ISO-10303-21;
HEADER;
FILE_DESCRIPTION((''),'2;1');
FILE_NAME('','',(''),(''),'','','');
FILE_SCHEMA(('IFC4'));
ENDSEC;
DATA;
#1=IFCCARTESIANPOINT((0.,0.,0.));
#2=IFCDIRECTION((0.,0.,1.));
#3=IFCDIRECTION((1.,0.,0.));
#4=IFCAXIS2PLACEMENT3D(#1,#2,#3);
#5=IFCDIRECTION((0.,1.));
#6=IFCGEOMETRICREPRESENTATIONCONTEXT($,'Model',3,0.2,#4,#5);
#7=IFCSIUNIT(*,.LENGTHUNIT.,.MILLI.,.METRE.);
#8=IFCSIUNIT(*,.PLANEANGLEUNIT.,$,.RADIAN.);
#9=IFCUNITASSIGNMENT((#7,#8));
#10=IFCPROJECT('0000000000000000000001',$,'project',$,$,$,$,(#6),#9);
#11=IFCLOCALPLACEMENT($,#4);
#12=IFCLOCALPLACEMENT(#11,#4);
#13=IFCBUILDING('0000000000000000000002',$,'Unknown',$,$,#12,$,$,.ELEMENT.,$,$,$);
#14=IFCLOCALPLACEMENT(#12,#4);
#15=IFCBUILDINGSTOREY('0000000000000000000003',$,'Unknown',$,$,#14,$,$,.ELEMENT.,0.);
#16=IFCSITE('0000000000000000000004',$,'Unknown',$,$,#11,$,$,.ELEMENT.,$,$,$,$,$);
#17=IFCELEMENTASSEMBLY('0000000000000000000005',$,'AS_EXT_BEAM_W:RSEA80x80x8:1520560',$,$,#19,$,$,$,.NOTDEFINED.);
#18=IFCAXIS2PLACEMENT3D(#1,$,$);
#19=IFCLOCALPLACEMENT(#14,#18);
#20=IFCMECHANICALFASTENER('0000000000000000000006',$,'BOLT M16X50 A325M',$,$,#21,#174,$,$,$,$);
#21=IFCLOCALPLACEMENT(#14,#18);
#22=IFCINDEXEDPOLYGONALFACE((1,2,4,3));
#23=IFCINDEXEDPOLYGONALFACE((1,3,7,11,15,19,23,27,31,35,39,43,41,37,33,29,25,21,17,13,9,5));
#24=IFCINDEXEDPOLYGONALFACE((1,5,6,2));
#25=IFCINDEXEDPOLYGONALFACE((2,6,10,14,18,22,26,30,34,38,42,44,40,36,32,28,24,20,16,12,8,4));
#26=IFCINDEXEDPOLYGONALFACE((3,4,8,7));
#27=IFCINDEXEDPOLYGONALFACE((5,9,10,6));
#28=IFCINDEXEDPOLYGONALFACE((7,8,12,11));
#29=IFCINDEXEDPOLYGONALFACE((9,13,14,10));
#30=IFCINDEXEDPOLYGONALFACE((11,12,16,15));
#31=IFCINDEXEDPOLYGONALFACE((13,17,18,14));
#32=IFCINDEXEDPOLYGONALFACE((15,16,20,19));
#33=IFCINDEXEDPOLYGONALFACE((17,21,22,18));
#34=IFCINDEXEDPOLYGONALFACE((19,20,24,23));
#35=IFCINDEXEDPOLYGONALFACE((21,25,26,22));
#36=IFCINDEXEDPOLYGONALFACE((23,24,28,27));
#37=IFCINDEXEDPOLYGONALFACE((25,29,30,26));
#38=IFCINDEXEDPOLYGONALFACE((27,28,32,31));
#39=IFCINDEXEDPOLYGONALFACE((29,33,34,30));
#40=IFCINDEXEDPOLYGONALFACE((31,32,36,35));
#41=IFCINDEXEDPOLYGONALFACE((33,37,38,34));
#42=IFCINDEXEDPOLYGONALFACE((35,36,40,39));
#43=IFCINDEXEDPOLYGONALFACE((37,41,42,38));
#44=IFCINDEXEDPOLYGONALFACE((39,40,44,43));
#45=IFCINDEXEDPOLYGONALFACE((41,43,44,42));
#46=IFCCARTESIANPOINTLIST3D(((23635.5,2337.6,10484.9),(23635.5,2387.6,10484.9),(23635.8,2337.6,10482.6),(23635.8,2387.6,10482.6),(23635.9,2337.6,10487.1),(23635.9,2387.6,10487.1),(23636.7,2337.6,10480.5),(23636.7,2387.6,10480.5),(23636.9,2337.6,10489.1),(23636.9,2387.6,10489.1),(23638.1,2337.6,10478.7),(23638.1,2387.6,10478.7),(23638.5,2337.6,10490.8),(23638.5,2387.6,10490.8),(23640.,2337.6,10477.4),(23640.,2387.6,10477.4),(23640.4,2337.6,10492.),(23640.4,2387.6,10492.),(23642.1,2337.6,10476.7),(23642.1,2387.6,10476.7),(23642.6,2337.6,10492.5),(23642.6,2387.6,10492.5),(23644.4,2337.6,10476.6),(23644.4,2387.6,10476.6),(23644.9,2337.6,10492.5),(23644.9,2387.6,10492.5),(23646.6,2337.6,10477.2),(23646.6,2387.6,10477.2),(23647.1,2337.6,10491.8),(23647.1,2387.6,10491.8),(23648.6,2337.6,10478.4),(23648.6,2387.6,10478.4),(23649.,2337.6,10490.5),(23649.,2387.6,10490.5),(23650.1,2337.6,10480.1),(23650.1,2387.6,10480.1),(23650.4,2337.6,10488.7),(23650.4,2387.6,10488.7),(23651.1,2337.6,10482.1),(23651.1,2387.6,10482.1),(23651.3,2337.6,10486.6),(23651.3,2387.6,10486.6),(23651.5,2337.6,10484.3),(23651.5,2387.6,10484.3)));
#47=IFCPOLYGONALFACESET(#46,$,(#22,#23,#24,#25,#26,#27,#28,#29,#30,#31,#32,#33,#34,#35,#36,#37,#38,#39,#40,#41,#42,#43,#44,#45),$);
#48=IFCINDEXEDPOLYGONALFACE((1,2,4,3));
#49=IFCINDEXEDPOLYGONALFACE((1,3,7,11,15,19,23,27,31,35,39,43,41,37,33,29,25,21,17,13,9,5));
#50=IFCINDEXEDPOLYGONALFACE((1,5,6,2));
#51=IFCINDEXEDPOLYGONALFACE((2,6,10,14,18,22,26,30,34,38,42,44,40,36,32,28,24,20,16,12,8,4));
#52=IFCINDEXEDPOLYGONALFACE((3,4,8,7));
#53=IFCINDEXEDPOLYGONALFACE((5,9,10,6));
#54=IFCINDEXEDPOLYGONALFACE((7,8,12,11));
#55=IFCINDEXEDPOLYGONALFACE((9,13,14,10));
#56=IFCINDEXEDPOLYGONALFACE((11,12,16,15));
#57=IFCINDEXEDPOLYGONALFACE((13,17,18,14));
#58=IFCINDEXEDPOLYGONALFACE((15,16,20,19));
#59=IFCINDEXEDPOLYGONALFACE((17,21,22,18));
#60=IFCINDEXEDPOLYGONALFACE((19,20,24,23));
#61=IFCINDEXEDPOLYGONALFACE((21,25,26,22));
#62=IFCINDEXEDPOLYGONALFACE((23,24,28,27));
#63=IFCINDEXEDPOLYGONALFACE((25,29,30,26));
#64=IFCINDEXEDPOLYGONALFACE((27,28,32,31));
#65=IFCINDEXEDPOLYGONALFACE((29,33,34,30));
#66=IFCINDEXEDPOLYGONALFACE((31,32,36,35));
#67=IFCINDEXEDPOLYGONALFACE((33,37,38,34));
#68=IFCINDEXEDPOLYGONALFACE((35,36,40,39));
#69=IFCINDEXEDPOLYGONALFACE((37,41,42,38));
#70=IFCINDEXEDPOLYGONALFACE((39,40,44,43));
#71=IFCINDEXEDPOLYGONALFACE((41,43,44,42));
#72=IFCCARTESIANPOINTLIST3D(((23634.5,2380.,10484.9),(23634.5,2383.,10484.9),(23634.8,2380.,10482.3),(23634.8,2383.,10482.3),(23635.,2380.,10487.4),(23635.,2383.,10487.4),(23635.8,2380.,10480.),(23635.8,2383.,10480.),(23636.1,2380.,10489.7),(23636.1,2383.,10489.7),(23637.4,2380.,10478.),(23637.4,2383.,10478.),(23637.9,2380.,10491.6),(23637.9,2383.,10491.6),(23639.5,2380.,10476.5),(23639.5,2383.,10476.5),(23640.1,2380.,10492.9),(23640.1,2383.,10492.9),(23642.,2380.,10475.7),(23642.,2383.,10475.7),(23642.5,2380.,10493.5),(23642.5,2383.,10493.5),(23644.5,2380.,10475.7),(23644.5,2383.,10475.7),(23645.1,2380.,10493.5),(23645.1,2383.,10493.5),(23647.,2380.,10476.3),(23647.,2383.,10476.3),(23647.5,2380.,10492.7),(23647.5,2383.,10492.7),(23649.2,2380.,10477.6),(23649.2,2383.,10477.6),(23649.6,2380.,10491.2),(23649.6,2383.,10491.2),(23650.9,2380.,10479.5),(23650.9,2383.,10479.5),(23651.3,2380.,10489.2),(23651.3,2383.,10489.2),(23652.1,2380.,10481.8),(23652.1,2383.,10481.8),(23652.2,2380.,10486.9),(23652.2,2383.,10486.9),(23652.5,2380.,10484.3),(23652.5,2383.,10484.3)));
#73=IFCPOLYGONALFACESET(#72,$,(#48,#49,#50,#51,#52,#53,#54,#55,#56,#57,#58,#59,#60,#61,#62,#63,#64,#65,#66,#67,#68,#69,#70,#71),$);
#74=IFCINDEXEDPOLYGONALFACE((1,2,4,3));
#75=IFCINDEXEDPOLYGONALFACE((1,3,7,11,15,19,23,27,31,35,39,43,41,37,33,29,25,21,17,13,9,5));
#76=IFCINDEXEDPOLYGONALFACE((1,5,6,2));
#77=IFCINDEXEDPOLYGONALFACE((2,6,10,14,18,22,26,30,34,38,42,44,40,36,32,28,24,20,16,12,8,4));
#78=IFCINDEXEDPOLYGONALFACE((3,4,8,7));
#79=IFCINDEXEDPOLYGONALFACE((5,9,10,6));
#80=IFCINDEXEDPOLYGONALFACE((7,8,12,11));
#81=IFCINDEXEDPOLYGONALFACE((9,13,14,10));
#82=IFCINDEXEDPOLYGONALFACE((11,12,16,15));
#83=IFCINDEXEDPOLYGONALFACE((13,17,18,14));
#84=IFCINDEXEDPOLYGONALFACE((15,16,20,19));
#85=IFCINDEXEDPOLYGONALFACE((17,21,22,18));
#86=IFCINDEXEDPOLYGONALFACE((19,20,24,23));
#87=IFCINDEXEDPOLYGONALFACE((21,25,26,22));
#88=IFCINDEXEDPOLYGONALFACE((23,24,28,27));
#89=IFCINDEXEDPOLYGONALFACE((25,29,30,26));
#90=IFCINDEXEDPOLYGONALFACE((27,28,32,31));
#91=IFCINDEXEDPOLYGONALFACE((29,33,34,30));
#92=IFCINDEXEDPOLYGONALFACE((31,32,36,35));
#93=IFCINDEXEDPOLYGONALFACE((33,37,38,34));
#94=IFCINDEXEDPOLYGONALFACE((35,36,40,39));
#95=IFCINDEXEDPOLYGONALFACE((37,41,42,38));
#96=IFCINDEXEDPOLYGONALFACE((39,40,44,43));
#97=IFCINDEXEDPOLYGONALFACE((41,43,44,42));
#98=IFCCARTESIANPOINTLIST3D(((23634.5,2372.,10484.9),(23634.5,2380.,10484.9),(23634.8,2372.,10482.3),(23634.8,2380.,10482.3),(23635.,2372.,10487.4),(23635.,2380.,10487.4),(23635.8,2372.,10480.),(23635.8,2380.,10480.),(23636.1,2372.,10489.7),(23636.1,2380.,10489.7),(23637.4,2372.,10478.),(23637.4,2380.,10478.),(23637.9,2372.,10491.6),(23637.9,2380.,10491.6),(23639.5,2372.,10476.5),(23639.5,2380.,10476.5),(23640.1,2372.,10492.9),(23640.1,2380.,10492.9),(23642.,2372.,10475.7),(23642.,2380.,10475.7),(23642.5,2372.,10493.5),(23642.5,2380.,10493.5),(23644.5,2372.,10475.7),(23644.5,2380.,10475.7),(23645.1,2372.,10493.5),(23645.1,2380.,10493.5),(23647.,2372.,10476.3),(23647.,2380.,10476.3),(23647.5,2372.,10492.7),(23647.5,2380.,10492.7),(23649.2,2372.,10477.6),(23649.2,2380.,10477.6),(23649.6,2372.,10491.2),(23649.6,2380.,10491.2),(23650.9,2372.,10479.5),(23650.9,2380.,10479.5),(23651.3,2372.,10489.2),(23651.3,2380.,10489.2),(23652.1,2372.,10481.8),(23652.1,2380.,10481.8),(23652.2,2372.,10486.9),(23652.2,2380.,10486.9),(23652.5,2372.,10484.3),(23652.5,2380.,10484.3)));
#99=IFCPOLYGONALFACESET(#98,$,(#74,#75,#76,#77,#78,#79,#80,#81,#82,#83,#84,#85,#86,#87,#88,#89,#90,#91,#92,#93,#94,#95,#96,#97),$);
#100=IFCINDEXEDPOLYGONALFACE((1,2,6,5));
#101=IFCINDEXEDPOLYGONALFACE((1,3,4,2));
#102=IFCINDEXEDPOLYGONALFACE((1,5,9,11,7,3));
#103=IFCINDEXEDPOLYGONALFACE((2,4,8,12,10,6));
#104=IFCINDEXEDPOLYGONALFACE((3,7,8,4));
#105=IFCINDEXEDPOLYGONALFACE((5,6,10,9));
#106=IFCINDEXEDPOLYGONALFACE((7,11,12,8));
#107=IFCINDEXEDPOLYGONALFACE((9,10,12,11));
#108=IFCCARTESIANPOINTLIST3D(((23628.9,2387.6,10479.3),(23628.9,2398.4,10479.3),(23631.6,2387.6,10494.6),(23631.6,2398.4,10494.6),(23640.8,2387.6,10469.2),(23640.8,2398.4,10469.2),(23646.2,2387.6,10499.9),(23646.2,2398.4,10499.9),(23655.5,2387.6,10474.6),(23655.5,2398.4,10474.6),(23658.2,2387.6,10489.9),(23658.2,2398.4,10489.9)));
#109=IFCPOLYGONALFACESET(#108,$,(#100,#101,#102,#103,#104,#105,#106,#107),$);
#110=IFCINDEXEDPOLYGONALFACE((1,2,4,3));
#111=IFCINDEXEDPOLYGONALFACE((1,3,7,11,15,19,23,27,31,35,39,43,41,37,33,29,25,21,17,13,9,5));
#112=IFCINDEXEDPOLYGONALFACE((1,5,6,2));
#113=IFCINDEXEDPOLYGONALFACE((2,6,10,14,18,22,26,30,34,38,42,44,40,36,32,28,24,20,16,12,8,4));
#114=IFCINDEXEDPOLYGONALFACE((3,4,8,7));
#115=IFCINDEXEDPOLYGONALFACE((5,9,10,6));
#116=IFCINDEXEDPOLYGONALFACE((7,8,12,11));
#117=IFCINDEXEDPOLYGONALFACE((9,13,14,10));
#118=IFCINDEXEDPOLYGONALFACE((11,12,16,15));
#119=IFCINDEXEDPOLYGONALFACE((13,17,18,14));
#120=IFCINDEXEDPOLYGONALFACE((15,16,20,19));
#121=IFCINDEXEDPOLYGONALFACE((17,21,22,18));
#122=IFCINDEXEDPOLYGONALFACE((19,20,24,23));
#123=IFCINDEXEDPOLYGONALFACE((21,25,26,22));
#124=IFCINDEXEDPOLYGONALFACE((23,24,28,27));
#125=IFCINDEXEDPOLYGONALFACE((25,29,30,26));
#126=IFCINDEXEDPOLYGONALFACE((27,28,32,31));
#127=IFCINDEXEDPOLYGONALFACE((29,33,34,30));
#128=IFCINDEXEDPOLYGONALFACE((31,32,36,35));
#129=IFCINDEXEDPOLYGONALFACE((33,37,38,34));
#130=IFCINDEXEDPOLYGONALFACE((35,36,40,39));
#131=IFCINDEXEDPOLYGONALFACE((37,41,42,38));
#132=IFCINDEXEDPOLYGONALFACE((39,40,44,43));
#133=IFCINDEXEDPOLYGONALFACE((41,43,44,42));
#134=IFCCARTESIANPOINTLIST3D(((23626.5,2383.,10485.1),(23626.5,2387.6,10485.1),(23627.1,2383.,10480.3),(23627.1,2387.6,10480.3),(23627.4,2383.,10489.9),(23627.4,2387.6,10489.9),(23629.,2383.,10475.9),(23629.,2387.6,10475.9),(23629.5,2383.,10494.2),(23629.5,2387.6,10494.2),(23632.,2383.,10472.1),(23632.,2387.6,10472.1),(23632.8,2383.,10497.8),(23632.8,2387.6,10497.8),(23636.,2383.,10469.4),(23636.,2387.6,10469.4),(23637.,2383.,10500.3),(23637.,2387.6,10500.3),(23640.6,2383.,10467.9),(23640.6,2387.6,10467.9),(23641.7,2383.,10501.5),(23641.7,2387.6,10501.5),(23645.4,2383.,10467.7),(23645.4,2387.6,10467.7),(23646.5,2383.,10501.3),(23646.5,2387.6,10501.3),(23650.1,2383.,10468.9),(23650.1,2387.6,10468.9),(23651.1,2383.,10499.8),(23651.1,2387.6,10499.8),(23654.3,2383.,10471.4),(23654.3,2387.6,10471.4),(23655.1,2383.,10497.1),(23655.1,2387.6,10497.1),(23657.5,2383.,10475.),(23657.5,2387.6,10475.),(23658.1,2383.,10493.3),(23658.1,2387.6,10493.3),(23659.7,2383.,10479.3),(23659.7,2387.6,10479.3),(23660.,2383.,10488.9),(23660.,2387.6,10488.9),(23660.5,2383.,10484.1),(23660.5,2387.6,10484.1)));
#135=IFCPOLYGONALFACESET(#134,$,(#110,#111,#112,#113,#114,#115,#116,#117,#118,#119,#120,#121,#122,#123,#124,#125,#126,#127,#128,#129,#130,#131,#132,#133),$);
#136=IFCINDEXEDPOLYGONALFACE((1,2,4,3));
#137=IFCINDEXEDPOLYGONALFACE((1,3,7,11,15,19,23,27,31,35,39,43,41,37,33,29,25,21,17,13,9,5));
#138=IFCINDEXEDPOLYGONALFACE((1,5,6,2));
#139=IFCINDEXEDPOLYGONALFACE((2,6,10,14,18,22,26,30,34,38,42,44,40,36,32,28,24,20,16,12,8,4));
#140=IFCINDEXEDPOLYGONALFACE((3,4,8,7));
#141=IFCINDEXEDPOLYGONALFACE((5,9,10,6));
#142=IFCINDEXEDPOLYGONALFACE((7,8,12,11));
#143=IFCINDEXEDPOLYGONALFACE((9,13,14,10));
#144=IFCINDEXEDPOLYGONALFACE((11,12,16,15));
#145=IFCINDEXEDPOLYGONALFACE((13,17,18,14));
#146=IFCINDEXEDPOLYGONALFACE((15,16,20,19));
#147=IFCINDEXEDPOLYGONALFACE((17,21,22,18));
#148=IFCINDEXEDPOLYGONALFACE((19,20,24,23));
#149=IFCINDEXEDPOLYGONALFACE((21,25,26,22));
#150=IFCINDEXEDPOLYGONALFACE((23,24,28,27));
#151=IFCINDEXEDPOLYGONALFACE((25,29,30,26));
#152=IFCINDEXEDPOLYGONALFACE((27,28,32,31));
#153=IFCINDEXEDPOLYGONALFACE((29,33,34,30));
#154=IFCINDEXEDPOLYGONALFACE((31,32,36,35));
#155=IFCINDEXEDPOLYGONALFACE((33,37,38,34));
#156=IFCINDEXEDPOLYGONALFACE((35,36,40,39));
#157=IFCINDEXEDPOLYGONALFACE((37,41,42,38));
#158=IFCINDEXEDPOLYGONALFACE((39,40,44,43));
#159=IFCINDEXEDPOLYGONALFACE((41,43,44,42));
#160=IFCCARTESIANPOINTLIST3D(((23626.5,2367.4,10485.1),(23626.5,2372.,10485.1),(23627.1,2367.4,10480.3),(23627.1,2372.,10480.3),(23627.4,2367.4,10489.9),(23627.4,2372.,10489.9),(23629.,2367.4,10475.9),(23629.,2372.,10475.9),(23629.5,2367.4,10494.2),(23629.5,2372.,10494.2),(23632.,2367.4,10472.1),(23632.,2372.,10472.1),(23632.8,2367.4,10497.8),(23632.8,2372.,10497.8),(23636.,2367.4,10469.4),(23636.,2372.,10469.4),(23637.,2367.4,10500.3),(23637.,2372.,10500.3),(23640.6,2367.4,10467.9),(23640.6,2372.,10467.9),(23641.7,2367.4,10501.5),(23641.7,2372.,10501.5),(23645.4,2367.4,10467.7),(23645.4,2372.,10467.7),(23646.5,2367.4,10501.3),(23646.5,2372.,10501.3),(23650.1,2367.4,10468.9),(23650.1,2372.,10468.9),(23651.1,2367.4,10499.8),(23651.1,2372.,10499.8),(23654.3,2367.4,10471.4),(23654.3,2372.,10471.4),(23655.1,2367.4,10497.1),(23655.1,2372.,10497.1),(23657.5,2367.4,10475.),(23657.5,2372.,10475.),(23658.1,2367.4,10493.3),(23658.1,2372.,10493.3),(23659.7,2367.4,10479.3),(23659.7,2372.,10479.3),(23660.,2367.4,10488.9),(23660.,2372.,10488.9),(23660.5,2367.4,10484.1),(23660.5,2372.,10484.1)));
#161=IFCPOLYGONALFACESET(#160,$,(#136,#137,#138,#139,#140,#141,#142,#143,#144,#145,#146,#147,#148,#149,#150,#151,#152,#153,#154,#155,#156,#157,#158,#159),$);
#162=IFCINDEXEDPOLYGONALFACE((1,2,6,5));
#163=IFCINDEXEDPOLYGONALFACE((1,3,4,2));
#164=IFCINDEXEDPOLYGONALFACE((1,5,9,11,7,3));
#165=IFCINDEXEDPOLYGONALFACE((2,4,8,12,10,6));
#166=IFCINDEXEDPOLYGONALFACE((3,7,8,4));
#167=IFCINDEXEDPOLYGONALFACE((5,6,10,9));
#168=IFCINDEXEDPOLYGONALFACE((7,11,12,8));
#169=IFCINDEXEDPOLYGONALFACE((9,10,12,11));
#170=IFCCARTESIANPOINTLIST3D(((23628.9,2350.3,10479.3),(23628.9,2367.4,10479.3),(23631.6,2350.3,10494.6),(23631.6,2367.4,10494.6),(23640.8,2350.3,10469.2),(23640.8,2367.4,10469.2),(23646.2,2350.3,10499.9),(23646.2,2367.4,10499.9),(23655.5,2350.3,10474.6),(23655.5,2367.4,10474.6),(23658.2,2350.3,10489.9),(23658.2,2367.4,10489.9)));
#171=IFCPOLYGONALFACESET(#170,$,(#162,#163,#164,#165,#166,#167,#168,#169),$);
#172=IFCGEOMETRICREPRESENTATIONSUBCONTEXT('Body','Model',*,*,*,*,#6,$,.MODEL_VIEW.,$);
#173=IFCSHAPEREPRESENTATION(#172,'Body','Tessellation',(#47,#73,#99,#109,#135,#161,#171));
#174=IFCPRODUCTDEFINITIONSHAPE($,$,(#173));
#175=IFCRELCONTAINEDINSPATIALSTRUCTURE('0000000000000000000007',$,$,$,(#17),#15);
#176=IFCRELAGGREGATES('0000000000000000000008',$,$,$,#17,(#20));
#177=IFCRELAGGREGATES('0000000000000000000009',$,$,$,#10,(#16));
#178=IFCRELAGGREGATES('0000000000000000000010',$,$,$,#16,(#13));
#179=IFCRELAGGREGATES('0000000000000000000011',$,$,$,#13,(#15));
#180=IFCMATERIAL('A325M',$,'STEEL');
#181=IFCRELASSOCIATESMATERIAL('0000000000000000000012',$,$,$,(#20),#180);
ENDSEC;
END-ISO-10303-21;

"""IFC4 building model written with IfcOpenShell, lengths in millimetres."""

from ifc_helpers import new_model, si_unit, direction, frame, origin_with_axes, place, context, subcontext, project, spatial, line, arc, indexed_curve, outline, extrude, source, transform, mapped, material, element, aggregate, save


model = new_model("IFC4")

# Units and contexts
model_context = context("Model", 3, precision=0.2, world=origin_with_axes(), true_north=direction((0.0, 1.0)))
body_context = subcontext(model_context, "Body", "Model", "MODEL_VIEW")
ifc_project = project(units=[si_unit("LENGTHUNIT", "METRE", prefix="MILLI"), si_unit("PLANEANGLEUNIT", "RADIAN")], contexts=[model_context])

# Site, building, storey
site_placement = place(None, origin_with_axes())
site = spatial("IfcSite", under=ifc_project, at=site_placement, Name="Unknown", CompositionType="ELEMENT")
building_placement = place(site_placement, origin_with_axes())
building = spatial("IfcBuilding", under=site, at=building_placement, Name="Unknown", CompositionType="ELEMENT")
storey_placement = place(building_placement, origin_with_axes())
storey = spatial("IfcBuildingStorey", under=building, at=storey_placement, Name="Unknown", CompositionType="ELEMENT", Elevation=0.0)

# Element assembly
assembly_1_placement = place(storey_placement, frame((23581.1, 2340.0, 10490.5), z_axis=(0.0, -1.0, 0.0), x_axis=(0.984808, 0.0, -0.173648)))
assembly_1 = element("IfcElementAssembly", 1, at=assembly_1_placement, inside=storey, Name="AS_EXT_BEAM_W:RSEA80x80x8:1520560", PredefinedType="NOTDEFINED")

# Mechanical fastener
ifc_material_1 = material(Name="A325M", Category="STEEL")
shared_shape = source(origin_with_axes(), body_context, "Body", "SweptSolid", [
    extrude(outline(indexed_curve([(8.0, 0.0), (0.0, 8.0), (-8.0, 0.0), (0.0, -8.0)], segments=[arc(1, 2, 3), arc(3, 4, 1)])), frame((0.0, 0.0, 15.6), z_axis=(0.0, 0.0, -1.0), x_axis=(0.0, 1.0, 0.0)), (0.0, 0.0, 1.0), 50.0),
    extrude(outline(indexed_curve([(9.0, 0.0), (0.0, 9.0), (-9.0, 0.0), (0.0, -9.0)], segments=[arc(1, 2, 3), arc(3, 4, 1)])), frame((0.0, 0.0, 11.0), z_axis=(0.0, 0.0, -1.0), x_axis=(0.0, 1.0, 0.0)), (0.0, 0.0, 1.0), 3.0),
    extrude(outline(indexed_curve([(9.0, 0.0), (0.0, 9.0), (-9.0, 0.0), (0.0, -9.0)], segments=[arc(1, 2, 3), arc(3, 4, 1)])), frame((0.0, 0.0, 8.0), z_axis=(0.0, 0.0, -1.0), x_axis=(0.0, 1.0, 0.0)), (0.0, 0.0, 1.0), 8.0),
    extrude(outline(indexed_curve([(15.6, 0.0), (7.8, 13.5), (-7.8, 13.5), (-15.6, 0.0), (-7.8, -13.5), (7.8, -13.5)], segments=[line(1, 2, 3, 4, 5, 6, 1)])), frame((0.0, 0.0, 26.4), z_axis=(0.0, 0.0, -1.0), x_axis=(0.0, 1.0, 0.0)), (0.0, 0.0, 1.0), 10.8),
    extrude(outline(indexed_curve([(17.0, 0.0), (0.0, 17.0), (-17.0, 0.0), (0.0, -17.0)], segments=[arc(1, 2, 3), arc(3, 4, 1)])), frame((0.0, 0.0, 15.6), z_axis=(0.0, 0.0, -1.0), x_axis=(0.0, 1.0, 0.0)), (0.0, 0.0, 1.0), 4.6),
    extrude(outline(indexed_curve([(17.0, 0.0), (0.0, 17.0), (-17.0, 0.0), (0.0, -17.0)], segments=[arc(1, 2, 3), arc(3, 4, 1)])), frame((0.0, 0.0, 0.0), z_axis=(0.0, 0.0, -1.0), x_axis=(0.0, 1.0, 0.0)), (0.0, 0.0, 1.0), 4.6),
    extrude(outline(indexed_curve([(15.6, 0.0), (7.8, 13.5), (-7.8, 13.5), (-15.6, 0.0), (-7.8, -13.5), (7.8, -13.5)], segments=[line(1, 2, 3, 4, 5, 6, 1)])), frame((0.0, 0.0, -4.6), z_axis=(0.0, 0.0, -1.0), x_axis=(0.0, 1.0, 0.0)), (0.0, 0.0, 1.0), 17.1),
])
mechanical_fastener_1_placement = place(assembly_1_placement, frame((62.5, 5.0, -32.0), z_axis=(0.0, 0.0, -1.0), x_axis=(1.0, 0.0, 0.0)))
mechanical_fastener_1 = element("IfcMechanicalFastener", 2, at=mechanical_fastener_1_placement, material=ifc_material_1, Name="BOLT M16X50 A325M", context=body_context, shape_type="MappedRepresentation", body=[
    mapped(shared_shape, transform((0.0, 0.0, 0.0))),
])
aggregate(assembly_1, [mechanical_fastener_1])

save(model, "model.ifc")
